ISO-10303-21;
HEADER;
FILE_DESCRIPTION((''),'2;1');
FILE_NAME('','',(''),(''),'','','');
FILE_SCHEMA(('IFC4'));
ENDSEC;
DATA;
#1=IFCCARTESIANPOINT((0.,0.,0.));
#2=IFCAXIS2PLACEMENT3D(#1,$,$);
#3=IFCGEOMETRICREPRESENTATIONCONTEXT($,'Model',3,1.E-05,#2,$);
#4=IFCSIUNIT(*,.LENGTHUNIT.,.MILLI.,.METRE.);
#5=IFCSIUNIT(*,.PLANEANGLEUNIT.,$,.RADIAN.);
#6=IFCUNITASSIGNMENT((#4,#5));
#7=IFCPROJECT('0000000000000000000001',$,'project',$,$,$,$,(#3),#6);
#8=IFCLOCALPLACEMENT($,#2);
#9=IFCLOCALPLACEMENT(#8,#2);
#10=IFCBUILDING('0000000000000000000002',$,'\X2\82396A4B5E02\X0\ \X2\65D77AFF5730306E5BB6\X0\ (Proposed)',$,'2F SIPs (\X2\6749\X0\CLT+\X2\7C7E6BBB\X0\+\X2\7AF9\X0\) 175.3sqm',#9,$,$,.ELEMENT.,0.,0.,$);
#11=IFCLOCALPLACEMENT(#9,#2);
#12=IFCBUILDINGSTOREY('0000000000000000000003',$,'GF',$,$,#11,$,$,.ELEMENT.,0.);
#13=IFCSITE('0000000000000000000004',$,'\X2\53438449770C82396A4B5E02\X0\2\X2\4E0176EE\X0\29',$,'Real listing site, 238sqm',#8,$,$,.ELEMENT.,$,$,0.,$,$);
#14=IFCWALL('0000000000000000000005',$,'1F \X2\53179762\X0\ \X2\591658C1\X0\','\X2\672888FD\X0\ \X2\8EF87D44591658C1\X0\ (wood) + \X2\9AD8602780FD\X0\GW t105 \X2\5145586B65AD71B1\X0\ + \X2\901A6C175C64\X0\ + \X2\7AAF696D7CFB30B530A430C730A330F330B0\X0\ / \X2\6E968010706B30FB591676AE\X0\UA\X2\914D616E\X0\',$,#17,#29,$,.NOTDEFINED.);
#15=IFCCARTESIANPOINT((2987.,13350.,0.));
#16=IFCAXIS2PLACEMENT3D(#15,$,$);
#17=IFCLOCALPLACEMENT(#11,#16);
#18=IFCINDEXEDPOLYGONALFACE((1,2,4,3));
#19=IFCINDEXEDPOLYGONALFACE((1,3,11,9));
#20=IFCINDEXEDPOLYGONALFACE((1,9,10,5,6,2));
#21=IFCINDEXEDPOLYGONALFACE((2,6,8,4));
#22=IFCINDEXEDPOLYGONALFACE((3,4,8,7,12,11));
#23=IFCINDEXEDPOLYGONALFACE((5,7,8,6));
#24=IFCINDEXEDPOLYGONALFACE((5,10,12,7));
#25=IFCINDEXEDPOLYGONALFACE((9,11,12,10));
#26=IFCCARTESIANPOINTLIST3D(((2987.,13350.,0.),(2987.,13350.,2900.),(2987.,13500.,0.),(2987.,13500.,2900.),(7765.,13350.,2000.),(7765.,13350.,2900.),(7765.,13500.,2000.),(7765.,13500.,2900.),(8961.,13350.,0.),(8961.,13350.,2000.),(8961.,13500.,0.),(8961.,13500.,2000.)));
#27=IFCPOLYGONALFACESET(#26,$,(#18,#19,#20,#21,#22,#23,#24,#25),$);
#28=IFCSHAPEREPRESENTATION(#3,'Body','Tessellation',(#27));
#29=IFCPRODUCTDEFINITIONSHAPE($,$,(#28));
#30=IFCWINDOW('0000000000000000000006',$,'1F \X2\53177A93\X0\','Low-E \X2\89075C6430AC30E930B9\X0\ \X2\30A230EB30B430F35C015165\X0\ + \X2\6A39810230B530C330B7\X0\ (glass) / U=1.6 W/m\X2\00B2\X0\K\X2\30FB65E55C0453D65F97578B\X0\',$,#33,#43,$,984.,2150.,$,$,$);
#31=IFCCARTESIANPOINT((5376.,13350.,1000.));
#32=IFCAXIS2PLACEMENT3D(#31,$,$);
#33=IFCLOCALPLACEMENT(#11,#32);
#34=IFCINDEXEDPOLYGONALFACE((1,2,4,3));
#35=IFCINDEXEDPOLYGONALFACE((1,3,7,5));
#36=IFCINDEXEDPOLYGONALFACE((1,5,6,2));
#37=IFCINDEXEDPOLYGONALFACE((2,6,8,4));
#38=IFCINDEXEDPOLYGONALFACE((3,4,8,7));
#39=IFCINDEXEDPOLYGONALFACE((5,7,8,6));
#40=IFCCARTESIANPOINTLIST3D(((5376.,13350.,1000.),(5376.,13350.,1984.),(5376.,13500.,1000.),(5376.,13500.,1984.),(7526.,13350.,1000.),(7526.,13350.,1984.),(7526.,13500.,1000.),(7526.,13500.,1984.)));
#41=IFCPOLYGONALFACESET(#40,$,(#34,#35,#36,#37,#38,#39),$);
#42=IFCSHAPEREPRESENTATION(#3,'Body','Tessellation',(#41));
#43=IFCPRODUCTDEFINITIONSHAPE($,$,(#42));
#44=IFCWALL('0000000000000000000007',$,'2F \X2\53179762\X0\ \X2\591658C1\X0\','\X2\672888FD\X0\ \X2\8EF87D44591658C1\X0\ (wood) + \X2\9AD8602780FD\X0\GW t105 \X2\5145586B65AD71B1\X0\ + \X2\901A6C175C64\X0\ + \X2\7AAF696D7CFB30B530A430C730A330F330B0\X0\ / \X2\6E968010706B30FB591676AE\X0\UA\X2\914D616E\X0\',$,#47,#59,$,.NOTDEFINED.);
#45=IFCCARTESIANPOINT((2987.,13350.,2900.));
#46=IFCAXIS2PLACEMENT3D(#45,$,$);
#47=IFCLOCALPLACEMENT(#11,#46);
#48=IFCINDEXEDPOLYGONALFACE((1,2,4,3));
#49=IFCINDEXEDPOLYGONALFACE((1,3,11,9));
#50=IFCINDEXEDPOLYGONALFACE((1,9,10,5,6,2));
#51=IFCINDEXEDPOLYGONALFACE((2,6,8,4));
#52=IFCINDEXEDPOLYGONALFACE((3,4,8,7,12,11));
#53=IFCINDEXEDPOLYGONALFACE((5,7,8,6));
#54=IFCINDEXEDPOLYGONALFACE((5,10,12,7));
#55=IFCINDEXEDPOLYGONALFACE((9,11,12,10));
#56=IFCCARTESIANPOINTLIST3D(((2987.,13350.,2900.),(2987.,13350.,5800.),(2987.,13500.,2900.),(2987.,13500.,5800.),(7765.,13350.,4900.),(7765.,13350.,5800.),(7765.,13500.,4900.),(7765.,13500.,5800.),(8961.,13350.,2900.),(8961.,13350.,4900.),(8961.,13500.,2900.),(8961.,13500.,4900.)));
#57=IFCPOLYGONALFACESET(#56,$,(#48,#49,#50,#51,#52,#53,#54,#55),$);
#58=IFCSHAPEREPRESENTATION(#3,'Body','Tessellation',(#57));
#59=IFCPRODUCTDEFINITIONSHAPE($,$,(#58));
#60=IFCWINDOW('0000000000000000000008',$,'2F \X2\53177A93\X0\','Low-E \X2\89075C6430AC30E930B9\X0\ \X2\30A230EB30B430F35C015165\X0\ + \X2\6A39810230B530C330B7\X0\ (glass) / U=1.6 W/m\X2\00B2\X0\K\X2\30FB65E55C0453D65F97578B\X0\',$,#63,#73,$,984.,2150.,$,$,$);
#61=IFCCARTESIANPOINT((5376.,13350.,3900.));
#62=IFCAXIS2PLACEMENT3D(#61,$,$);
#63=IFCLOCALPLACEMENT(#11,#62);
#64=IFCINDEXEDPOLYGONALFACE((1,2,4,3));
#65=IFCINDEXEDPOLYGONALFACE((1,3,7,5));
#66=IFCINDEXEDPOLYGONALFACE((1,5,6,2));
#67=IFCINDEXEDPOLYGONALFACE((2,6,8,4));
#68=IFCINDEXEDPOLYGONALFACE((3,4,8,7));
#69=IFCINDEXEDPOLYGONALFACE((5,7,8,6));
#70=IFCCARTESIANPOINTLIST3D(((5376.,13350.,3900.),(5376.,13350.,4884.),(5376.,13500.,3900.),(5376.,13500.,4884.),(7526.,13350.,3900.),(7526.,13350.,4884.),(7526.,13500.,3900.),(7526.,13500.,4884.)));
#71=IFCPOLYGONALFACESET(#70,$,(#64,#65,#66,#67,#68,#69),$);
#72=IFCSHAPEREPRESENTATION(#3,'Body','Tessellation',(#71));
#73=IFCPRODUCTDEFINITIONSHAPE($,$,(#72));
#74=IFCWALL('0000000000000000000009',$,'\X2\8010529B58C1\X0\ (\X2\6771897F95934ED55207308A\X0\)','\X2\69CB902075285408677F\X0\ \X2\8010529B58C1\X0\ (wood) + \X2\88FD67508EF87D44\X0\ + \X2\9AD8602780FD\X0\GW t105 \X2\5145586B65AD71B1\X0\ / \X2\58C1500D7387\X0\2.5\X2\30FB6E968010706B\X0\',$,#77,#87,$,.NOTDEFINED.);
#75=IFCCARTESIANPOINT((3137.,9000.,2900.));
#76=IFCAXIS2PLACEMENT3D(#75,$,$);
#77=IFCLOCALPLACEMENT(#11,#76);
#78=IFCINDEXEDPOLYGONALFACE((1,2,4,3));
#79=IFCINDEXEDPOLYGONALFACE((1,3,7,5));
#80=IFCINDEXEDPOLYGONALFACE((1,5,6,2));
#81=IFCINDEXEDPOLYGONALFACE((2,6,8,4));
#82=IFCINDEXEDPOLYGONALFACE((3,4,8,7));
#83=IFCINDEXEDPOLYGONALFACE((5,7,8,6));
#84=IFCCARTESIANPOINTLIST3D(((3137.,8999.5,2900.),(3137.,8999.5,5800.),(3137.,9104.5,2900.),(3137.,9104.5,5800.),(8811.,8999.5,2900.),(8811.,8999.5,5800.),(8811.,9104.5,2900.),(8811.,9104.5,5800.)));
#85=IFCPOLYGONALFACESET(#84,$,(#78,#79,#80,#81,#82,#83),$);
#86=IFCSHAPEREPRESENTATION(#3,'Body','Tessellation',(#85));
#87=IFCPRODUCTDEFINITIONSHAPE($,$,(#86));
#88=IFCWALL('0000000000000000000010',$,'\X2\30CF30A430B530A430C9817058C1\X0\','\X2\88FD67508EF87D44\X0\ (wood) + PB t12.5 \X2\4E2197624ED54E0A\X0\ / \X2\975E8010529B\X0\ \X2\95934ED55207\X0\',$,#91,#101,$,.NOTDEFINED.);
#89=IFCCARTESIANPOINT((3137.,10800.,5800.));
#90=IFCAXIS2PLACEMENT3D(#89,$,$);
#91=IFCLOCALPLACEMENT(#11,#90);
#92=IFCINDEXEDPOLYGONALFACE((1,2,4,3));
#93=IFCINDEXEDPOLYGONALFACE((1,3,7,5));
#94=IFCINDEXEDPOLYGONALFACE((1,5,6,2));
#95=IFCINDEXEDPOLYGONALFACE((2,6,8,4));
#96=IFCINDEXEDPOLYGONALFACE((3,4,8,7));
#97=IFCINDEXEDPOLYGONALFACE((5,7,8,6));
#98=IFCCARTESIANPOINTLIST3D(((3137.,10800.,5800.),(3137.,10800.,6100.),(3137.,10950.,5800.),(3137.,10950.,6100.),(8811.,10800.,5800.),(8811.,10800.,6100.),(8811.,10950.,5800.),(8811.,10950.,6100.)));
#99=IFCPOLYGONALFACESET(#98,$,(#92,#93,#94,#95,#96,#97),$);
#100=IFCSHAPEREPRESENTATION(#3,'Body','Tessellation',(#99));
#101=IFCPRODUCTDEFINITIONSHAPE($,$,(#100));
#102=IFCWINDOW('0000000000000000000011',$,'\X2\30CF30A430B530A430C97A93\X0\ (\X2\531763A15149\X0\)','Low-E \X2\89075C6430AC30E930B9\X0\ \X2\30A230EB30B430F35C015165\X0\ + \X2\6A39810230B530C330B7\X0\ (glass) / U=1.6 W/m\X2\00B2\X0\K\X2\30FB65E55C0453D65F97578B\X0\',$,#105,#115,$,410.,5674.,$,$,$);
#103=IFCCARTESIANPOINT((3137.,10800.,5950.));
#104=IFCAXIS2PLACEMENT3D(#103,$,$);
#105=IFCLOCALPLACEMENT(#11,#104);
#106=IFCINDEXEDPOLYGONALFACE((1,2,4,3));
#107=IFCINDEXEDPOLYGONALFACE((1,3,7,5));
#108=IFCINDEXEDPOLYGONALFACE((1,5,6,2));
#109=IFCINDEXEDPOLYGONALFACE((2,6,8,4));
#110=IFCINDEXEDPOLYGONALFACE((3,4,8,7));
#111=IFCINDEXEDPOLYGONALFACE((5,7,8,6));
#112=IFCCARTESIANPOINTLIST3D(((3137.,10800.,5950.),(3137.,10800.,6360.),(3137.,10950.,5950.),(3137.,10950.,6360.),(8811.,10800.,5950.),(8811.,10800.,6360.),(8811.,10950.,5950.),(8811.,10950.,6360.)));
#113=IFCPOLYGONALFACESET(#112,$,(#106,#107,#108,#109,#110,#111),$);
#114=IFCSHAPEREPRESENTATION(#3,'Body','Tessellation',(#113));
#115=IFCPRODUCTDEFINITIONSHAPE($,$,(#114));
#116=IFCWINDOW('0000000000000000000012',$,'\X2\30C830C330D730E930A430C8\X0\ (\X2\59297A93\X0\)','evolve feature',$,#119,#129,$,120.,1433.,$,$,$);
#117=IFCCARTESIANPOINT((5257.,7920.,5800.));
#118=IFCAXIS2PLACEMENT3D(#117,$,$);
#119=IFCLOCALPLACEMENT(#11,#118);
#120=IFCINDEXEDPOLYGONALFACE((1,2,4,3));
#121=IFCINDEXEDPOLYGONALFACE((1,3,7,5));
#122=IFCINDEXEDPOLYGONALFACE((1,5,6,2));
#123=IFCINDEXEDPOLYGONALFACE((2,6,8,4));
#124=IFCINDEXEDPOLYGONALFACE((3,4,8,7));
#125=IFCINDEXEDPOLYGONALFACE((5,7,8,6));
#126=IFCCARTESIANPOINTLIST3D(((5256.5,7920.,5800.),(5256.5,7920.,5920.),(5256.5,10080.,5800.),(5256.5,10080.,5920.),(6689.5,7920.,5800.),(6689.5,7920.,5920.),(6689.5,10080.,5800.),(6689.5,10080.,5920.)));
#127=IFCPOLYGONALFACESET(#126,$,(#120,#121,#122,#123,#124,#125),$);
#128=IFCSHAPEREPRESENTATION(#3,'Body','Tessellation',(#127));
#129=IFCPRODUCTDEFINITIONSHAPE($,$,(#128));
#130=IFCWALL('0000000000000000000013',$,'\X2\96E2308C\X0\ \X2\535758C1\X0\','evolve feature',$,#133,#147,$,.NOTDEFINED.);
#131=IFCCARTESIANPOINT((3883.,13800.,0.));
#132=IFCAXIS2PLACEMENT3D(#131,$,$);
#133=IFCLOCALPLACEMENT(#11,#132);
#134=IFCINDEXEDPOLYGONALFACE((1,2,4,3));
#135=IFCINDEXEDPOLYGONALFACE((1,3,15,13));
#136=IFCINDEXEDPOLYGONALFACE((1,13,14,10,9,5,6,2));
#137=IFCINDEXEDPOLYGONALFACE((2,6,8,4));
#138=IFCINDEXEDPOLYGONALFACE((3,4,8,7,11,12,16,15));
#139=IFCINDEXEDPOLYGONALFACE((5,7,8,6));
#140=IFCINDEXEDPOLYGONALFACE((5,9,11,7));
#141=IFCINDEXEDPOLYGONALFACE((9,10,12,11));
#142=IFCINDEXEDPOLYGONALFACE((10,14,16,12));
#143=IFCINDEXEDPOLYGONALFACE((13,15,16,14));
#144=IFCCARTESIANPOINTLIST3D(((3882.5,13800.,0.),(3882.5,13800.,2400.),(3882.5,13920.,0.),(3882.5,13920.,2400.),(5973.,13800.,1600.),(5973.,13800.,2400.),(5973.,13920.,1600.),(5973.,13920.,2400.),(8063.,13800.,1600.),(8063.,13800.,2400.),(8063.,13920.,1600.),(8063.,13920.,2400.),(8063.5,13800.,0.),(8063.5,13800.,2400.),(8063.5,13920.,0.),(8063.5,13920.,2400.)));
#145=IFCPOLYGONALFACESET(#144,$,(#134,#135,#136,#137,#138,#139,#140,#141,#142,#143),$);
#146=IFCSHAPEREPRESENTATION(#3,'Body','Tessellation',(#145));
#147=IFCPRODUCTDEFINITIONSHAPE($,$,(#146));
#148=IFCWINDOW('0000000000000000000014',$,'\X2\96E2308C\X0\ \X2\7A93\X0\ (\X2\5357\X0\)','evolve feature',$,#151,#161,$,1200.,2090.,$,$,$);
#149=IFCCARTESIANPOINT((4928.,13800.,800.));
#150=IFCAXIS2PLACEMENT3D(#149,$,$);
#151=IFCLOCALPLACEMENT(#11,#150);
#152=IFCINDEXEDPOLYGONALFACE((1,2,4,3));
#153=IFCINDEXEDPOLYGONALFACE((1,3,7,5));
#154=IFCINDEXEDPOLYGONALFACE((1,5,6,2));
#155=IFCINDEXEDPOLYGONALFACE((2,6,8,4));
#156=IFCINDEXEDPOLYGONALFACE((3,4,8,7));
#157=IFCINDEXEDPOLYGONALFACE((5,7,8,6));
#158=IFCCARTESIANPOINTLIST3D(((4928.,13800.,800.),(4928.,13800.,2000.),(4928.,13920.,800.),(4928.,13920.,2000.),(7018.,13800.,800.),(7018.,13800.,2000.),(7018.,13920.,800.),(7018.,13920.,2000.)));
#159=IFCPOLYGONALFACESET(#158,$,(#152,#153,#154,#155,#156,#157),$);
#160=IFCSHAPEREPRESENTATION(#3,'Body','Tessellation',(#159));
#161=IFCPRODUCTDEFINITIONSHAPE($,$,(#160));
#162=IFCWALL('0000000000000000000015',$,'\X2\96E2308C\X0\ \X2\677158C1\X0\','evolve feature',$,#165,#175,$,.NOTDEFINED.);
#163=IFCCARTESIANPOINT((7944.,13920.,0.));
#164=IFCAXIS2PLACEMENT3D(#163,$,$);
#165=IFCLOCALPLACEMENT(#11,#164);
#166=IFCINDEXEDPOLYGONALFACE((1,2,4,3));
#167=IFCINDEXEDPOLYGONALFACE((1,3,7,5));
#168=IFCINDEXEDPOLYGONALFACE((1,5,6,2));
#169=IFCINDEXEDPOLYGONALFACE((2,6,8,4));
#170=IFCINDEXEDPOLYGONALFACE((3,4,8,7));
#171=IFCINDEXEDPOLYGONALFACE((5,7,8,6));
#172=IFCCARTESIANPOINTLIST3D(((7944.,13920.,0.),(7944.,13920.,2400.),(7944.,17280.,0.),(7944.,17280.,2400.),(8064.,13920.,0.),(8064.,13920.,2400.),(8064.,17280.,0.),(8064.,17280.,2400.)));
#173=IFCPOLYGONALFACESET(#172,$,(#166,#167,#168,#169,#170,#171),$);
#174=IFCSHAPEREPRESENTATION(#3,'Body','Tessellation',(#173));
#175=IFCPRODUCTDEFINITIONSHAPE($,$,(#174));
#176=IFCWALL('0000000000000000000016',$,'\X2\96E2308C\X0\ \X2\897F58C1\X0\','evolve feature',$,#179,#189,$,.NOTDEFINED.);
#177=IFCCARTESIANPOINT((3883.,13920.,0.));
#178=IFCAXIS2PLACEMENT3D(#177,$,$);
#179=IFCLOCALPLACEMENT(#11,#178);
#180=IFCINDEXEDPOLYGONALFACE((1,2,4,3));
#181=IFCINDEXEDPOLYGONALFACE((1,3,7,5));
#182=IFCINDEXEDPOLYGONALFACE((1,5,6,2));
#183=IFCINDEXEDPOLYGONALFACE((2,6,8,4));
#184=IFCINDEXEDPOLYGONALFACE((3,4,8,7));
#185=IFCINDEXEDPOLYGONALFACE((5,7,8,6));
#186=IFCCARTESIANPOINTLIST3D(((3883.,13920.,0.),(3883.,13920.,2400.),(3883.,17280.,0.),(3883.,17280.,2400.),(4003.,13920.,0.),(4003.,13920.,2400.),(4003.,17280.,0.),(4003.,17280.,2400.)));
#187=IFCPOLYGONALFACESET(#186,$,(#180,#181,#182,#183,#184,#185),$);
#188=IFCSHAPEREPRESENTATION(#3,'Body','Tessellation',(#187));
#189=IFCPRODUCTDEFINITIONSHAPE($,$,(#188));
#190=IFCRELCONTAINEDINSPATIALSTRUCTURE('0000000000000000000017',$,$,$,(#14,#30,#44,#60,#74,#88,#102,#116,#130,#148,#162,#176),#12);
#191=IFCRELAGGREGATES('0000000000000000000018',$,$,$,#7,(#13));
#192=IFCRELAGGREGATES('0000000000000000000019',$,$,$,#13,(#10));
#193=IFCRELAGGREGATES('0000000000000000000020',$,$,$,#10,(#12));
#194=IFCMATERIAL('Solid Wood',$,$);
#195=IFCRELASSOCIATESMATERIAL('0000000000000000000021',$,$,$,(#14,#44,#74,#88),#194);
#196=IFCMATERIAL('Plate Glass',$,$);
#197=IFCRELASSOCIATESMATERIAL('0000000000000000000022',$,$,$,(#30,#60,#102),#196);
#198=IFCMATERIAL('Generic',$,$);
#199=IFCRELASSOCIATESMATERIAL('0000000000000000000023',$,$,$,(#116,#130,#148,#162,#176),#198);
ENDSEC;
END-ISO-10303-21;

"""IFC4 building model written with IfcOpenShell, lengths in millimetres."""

from ifc_helpers import new_model, si_unit, frame, frame_2d, origin, place, context, project, spatial, rectangle, extrude, material, element, fill, save


model = new_model("IFC4")

# Units and contexts
model_context = context("Model", 3, precision=1e-05, world=origin())
ifc_project = project(units=[si_unit("LENGTHUNIT", "METRE", prefix="MILLI"), si_unit("PLANEANGLEUNIT", "RADIAN")], contexts=[model_context])

# Site, building, storey
site_placement = place(None, origin())
site = spatial("IfcSite", under=ifc_project, at=site_placement, Name="千葉県船橋市2丁目29", ObjectType="Real listing site, 238sqm", CompositionType="ELEMENT", RefElevation=0.0)
building_placement = place(site_placement, origin())
building = spatial("IfcBuilding", under=site, at=building_placement, Name="船橋市 旗竿地の家 (Proposed)", ObjectType="2F SIPs (杉CLT+籾殻+竹) 175.3sqm", CompositionType="ELEMENT", ElevationOfRefHeight=0.0, ElevationOfTerrain=0.0)
storey_placement = place(building_placement, origin())
storey = spatial("IfcBuildingStorey", under=building, at=storey_placement, Name="GF", CompositionType="ELEMENT", Elevation=0.0)

# Shared definitions
ifc_material_1 = material(Name="Generic")

# Wall, opening, window
ifc_material_2 = material(Name="Solid Wood")
wall_1_placement = place(storey_placement, frame((2987.0, 13350.0, 0.0)))
wall_1 = element("IfcWall", 1, at=wall_1_placement, inside=storey, material=ifc_material_2, Name="1F 北面 外壁", Description="木製 軸組外壁 (wood) + 高性能GW t105 充填断熱 + 通気層 + 窯業系サイディング / 準耐火・外皮UA配慮", PredefinedType="NOTDEFINED", context=model_context, shape_type="SweptSolid", body=[
    extrude(rectangle(XDim=5974.0, YDim=150.0, at=frame_2d((2987.0, 75.0))), frame((2987.0, 13350.0, 0.0)), (0.0, 0.0, 1.0), 2900.0),
])
opening_1_placement = place(storey_placement, frame((5376.0, 13350.0, 1000.0)))
opening_1 = element("IfcOpeningElement", 2, at=opening_1_placement, cuts=wall_1, PredefinedType="NOTDEFINED", context=model_context, shape_type="SweptSolid", body=[
    extrude(rectangle(XDim=2150.0, YDim=150.0, at=frame_2d((1075.0, 75.0))), frame((5376.0, 13350.0, 1000.0)), (0.0, 0.0, 1.0), 984.0),
])
ifc_material_3 = material(Name="Plate Glass")
window_1_placement = place(storey_placement, frame((5376.0, 13350.0, 1000.0)))
window_1 = element("IfcWindow", 3, at=window_1_placement, inside=storey, material=ifc_material_3, Name="1F 北窓", Description="Low-E 複層ガラス アルゴン封入 + 樹脂サッシ (glass) / U=1.6 W/m²K・日射取得型", OverallHeight=984.0, OverallWidth=2150.0, context=model_context, shape_type="SweptSolid", body=[
    extrude(rectangle(XDim=2150.0, YDim=150.0, at=frame_2d((1075.0, 75.0))), frame((5376.0, 13350.0, 1000.0)), (0.0, 0.0, 1.0), 984.0),
])
fill(opening_1, window_1)

# Wall, opening, window
wall_2_placement = place(storey_placement, frame((2987.0, 13350.0, 2900.0)))
wall_2 = element("IfcWall", 4, at=wall_2_placement, inside=storey, material=ifc_material_2, Name="2F 北面 外壁", Description="木製 軸組外壁 (wood) + 高性能GW t105 充填断熱 + 通気層 + 窯業系サイディング / 準耐火・外皮UA配慮", PredefinedType="NOTDEFINED", context=model_context, shape_type="SweptSolid", body=[
    extrude(rectangle(XDim=5974.0, YDim=150.0, at=frame_2d((2987.0, 75.0))), frame((2987.0, 13350.0, 2900.0)), (0.0, 0.0, 1.0), 2900.0),
])
opening_2_placement = place(storey_placement, frame((5376.0, 13350.0, 3900.0)))
opening_2 = element("IfcOpeningElement", 5, at=opening_2_placement, cuts=wall_2, PredefinedType="NOTDEFINED", context=model_context, shape_type="SweptSolid", body=[
    extrude(rectangle(XDim=2150.0, YDim=150.0, at=frame_2d((1075.0, 75.0))), frame((5376.0, 13350.0, 3900.0)), (0.0, 0.0, 1.0), 984.0),
])
window_2_placement = place(storey_placement, frame((5376.0, 13350.0, 3900.0)))
window_2 = element("IfcWindow", 6, at=window_2_placement, inside=storey, material=ifc_material_3, Name="2F 北窓", Description="Low-E 複層ガラス アルゴン封入 + 樹脂サッシ (glass) / U=1.6 W/m²K・日射取得型", OverallHeight=984.0, OverallWidth=2150.0, context=model_context, shape_type="SweptSolid", body=[
    extrude(rectangle(XDim=2150.0, YDim=150.0, at=frame_2d((1075.0, 75.0))), frame((5376.0, 13350.0, 3900.0)), (0.0, 0.0, 1.0), 984.0),
])
fill(opening_2, window_2)

# Wall
wall_3_placement = place(storey_placement, frame((3137.0, 9000.0, 2900.0)))
element("IfcWall", 7, at=wall_3_placement, inside=storey, material=ifc_material_2, Name="耐力壁 (東西間仕切り)", Description="構造用合板 耐力壁 (wood) + 製材軸組 + 高性能GW t105 充填断熱 / 壁倍率2.5・準耐火", PredefinedType="NOTDEFINED", context=model_context, shape_type="SweptSolid", body=[
    extrude(rectangle(XDim=5674.0, YDim=105.0, at=frame_2d((2837.0, 52.0))), frame((3137.0, 9000.0, 2900.0)), (0.0, 0.0, 1.0), 2900.0),
])

# Wall, opening, window
wall_4_placement = place(storey_placement, frame((3137.0, 10800.0, 5800.0)))
wall_4 = element("IfcWall", 8, at=wall_4_placement, inside=storey, material=ifc_material_2, Name="ハイサイド腰壁", Description="製材軸組 (wood) + PB t12.5 両面仕上 / 非耐力 間仕切", PredefinedType="NOTDEFINED", context=model_context, shape_type="SweptSolid", body=[
    extrude(rectangle(XDim=5674.0, YDim=150.0, at=frame_2d((2837.0, 75.0))), frame((3137.0, 10800.0, 5800.0)), (0.0, 0.0, 1.0), 700.0),
])
opening_3_placement = place(storey_placement, frame((3137.0, 10800.0, 5950.0)))
opening_3 = element("IfcOpeningElement", 9, at=opening_3_placement, cuts=wall_4, PredefinedType="NOTDEFINED", context=model_context, shape_type="SweptSolid", body=[
    extrude(rectangle(XDim=5674.0, YDim=150.0, at=frame_2d((2837.0, 75.0))), frame((3137.0, 10800.0, 5950.0)), (0.0, 0.0, 1.0), 410.0),
])
window_3_placement = place(storey_placement, frame((3137.0, 10800.0, 5950.0)))
window_3 = element("IfcWindow", 10, at=window_3_placement, inside=storey, material=ifc_material_3, Name="ハイサイド窓 (北採光)", Description="Low-E 複層ガラス アルゴン封入 + 樹脂サッシ (glass) / U=1.6 W/m²K・日射取得型", OverallHeight=410.0, OverallWidth=5674.0, context=model_context, shape_type="SweptSolid", body=[
    extrude(rectangle(XDim=5674.0, YDim=150.0, at=frame_2d((2837.0, 75.0))), frame((3137.0, 10800.0, 5950.0)), (0.0, 0.0, 1.0), 410.0),
])
fill(opening_3, window_3)

# Window
window_4_placement = place(storey_placement, frame((5257.0, 7920.0, 5800.0)))
element("IfcWindow", 11, at=window_4_placement, inside=storey, material=ifc_material_1, Name="トップライト (天窓)", Description="evolve feature", OverallHeight=120.0, OverallWidth=1433.0, context=model_context, shape_type="SweptSolid", body=[
    extrude(rectangle(XDim=1433.0, YDim=2160.0, at=frame_2d((716.0, 1080.0))), frame((5257.0, 7920.0, 5800.0)), (0.0, 0.0, 1.0), 120.0),
])

# Wall, opening, window
wall_5_placement = place(storey_placement, frame((3883.0, 13800.0, 0.0)))
wall_5 = element("IfcWall", 12, at=wall_5_placement, inside=storey, material=ifc_material_1, Name="離れ 南壁", Description="evolve feature", PredefinedType="NOTDEFINED", context=model_context, shape_type="SweptSolid", body=[
    extrude(rectangle(XDim=4181.0, YDim=120.0, at=frame_2d((2090.0, 60.0))), frame((3883.0, 13800.0, 0.0)), (0.0, 0.0, 1.0), 2400.0),
])
opening_4_placement = place(storey_placement, frame((4928.0, 13800.0, 800.0)))
opening_4 = element("IfcOpeningElement", 13, at=opening_4_placement, cuts=wall_5, PredefinedType="NOTDEFINED", context=model_context, shape_type="SweptSolid", body=[
    extrude(rectangle(XDim=2090.0, YDim=120.0, at=frame_2d((1045.0, 60.0))), frame((4928.0, 13800.0, 800.0)), (0.0, 0.0, 1.0), 1200.0),
])
window_5_placement = place(storey_placement, frame((4928.0, 13800.0, 800.0)))
window_5 = element("IfcWindow", 14, at=window_5_placement, inside=storey, material=ifc_material_1, Name="離れ 窓 (南)", Description="evolve feature", OverallHeight=1200.0, OverallWidth=2090.0, context=model_context, shape_type="SweptSolid", body=[
    extrude(rectangle(XDim=2090.0, YDim=120.0, at=frame_2d((1045.0, 60.0))), frame((4928.0, 13800.0, 800.0)), (0.0, 0.0, 1.0), 1200.0),
])
fill(opening_4, window_5)

# Walls
wall_6_placement = place(storey_placement, frame((7944.0, 13920.0, 0.0)))
element("IfcWall", 15, at=wall_6_placement, inside=storey, material=ifc_material_1, Name="離れ 東壁", Description="evolve feature", PredefinedType="NOTDEFINED", context=model_context, shape_type="SweptSolid", body=[
    extrude(rectangle(XDim=120.0, YDim=3360.0, at=frame_2d((60.0, 1680.0))), frame((7944.0, 13920.0, 0.0)), (0.0, 0.0, 1.0), 2400.0),
])
wall_7_placement = place(storey_placement, frame((3883.0, 13920.0, 0.0)))
element("IfcWall", 16, at=wall_7_placement, inside=storey, material=ifc_material_1, Name="離れ 西壁", Description="evolve feature", PredefinedType="NOTDEFINED", context=model_context, shape_type="SweptSolid", body=[
    extrude(rectangle(XDim=120.0, YDim=3360.0, at=frame_2d((60.0, 1680.0))), frame((3883.0, 13920.0, 0.0)), (0.0, 0.0, 1.0), 2400.0),
])

save(model, "model.ifc")
